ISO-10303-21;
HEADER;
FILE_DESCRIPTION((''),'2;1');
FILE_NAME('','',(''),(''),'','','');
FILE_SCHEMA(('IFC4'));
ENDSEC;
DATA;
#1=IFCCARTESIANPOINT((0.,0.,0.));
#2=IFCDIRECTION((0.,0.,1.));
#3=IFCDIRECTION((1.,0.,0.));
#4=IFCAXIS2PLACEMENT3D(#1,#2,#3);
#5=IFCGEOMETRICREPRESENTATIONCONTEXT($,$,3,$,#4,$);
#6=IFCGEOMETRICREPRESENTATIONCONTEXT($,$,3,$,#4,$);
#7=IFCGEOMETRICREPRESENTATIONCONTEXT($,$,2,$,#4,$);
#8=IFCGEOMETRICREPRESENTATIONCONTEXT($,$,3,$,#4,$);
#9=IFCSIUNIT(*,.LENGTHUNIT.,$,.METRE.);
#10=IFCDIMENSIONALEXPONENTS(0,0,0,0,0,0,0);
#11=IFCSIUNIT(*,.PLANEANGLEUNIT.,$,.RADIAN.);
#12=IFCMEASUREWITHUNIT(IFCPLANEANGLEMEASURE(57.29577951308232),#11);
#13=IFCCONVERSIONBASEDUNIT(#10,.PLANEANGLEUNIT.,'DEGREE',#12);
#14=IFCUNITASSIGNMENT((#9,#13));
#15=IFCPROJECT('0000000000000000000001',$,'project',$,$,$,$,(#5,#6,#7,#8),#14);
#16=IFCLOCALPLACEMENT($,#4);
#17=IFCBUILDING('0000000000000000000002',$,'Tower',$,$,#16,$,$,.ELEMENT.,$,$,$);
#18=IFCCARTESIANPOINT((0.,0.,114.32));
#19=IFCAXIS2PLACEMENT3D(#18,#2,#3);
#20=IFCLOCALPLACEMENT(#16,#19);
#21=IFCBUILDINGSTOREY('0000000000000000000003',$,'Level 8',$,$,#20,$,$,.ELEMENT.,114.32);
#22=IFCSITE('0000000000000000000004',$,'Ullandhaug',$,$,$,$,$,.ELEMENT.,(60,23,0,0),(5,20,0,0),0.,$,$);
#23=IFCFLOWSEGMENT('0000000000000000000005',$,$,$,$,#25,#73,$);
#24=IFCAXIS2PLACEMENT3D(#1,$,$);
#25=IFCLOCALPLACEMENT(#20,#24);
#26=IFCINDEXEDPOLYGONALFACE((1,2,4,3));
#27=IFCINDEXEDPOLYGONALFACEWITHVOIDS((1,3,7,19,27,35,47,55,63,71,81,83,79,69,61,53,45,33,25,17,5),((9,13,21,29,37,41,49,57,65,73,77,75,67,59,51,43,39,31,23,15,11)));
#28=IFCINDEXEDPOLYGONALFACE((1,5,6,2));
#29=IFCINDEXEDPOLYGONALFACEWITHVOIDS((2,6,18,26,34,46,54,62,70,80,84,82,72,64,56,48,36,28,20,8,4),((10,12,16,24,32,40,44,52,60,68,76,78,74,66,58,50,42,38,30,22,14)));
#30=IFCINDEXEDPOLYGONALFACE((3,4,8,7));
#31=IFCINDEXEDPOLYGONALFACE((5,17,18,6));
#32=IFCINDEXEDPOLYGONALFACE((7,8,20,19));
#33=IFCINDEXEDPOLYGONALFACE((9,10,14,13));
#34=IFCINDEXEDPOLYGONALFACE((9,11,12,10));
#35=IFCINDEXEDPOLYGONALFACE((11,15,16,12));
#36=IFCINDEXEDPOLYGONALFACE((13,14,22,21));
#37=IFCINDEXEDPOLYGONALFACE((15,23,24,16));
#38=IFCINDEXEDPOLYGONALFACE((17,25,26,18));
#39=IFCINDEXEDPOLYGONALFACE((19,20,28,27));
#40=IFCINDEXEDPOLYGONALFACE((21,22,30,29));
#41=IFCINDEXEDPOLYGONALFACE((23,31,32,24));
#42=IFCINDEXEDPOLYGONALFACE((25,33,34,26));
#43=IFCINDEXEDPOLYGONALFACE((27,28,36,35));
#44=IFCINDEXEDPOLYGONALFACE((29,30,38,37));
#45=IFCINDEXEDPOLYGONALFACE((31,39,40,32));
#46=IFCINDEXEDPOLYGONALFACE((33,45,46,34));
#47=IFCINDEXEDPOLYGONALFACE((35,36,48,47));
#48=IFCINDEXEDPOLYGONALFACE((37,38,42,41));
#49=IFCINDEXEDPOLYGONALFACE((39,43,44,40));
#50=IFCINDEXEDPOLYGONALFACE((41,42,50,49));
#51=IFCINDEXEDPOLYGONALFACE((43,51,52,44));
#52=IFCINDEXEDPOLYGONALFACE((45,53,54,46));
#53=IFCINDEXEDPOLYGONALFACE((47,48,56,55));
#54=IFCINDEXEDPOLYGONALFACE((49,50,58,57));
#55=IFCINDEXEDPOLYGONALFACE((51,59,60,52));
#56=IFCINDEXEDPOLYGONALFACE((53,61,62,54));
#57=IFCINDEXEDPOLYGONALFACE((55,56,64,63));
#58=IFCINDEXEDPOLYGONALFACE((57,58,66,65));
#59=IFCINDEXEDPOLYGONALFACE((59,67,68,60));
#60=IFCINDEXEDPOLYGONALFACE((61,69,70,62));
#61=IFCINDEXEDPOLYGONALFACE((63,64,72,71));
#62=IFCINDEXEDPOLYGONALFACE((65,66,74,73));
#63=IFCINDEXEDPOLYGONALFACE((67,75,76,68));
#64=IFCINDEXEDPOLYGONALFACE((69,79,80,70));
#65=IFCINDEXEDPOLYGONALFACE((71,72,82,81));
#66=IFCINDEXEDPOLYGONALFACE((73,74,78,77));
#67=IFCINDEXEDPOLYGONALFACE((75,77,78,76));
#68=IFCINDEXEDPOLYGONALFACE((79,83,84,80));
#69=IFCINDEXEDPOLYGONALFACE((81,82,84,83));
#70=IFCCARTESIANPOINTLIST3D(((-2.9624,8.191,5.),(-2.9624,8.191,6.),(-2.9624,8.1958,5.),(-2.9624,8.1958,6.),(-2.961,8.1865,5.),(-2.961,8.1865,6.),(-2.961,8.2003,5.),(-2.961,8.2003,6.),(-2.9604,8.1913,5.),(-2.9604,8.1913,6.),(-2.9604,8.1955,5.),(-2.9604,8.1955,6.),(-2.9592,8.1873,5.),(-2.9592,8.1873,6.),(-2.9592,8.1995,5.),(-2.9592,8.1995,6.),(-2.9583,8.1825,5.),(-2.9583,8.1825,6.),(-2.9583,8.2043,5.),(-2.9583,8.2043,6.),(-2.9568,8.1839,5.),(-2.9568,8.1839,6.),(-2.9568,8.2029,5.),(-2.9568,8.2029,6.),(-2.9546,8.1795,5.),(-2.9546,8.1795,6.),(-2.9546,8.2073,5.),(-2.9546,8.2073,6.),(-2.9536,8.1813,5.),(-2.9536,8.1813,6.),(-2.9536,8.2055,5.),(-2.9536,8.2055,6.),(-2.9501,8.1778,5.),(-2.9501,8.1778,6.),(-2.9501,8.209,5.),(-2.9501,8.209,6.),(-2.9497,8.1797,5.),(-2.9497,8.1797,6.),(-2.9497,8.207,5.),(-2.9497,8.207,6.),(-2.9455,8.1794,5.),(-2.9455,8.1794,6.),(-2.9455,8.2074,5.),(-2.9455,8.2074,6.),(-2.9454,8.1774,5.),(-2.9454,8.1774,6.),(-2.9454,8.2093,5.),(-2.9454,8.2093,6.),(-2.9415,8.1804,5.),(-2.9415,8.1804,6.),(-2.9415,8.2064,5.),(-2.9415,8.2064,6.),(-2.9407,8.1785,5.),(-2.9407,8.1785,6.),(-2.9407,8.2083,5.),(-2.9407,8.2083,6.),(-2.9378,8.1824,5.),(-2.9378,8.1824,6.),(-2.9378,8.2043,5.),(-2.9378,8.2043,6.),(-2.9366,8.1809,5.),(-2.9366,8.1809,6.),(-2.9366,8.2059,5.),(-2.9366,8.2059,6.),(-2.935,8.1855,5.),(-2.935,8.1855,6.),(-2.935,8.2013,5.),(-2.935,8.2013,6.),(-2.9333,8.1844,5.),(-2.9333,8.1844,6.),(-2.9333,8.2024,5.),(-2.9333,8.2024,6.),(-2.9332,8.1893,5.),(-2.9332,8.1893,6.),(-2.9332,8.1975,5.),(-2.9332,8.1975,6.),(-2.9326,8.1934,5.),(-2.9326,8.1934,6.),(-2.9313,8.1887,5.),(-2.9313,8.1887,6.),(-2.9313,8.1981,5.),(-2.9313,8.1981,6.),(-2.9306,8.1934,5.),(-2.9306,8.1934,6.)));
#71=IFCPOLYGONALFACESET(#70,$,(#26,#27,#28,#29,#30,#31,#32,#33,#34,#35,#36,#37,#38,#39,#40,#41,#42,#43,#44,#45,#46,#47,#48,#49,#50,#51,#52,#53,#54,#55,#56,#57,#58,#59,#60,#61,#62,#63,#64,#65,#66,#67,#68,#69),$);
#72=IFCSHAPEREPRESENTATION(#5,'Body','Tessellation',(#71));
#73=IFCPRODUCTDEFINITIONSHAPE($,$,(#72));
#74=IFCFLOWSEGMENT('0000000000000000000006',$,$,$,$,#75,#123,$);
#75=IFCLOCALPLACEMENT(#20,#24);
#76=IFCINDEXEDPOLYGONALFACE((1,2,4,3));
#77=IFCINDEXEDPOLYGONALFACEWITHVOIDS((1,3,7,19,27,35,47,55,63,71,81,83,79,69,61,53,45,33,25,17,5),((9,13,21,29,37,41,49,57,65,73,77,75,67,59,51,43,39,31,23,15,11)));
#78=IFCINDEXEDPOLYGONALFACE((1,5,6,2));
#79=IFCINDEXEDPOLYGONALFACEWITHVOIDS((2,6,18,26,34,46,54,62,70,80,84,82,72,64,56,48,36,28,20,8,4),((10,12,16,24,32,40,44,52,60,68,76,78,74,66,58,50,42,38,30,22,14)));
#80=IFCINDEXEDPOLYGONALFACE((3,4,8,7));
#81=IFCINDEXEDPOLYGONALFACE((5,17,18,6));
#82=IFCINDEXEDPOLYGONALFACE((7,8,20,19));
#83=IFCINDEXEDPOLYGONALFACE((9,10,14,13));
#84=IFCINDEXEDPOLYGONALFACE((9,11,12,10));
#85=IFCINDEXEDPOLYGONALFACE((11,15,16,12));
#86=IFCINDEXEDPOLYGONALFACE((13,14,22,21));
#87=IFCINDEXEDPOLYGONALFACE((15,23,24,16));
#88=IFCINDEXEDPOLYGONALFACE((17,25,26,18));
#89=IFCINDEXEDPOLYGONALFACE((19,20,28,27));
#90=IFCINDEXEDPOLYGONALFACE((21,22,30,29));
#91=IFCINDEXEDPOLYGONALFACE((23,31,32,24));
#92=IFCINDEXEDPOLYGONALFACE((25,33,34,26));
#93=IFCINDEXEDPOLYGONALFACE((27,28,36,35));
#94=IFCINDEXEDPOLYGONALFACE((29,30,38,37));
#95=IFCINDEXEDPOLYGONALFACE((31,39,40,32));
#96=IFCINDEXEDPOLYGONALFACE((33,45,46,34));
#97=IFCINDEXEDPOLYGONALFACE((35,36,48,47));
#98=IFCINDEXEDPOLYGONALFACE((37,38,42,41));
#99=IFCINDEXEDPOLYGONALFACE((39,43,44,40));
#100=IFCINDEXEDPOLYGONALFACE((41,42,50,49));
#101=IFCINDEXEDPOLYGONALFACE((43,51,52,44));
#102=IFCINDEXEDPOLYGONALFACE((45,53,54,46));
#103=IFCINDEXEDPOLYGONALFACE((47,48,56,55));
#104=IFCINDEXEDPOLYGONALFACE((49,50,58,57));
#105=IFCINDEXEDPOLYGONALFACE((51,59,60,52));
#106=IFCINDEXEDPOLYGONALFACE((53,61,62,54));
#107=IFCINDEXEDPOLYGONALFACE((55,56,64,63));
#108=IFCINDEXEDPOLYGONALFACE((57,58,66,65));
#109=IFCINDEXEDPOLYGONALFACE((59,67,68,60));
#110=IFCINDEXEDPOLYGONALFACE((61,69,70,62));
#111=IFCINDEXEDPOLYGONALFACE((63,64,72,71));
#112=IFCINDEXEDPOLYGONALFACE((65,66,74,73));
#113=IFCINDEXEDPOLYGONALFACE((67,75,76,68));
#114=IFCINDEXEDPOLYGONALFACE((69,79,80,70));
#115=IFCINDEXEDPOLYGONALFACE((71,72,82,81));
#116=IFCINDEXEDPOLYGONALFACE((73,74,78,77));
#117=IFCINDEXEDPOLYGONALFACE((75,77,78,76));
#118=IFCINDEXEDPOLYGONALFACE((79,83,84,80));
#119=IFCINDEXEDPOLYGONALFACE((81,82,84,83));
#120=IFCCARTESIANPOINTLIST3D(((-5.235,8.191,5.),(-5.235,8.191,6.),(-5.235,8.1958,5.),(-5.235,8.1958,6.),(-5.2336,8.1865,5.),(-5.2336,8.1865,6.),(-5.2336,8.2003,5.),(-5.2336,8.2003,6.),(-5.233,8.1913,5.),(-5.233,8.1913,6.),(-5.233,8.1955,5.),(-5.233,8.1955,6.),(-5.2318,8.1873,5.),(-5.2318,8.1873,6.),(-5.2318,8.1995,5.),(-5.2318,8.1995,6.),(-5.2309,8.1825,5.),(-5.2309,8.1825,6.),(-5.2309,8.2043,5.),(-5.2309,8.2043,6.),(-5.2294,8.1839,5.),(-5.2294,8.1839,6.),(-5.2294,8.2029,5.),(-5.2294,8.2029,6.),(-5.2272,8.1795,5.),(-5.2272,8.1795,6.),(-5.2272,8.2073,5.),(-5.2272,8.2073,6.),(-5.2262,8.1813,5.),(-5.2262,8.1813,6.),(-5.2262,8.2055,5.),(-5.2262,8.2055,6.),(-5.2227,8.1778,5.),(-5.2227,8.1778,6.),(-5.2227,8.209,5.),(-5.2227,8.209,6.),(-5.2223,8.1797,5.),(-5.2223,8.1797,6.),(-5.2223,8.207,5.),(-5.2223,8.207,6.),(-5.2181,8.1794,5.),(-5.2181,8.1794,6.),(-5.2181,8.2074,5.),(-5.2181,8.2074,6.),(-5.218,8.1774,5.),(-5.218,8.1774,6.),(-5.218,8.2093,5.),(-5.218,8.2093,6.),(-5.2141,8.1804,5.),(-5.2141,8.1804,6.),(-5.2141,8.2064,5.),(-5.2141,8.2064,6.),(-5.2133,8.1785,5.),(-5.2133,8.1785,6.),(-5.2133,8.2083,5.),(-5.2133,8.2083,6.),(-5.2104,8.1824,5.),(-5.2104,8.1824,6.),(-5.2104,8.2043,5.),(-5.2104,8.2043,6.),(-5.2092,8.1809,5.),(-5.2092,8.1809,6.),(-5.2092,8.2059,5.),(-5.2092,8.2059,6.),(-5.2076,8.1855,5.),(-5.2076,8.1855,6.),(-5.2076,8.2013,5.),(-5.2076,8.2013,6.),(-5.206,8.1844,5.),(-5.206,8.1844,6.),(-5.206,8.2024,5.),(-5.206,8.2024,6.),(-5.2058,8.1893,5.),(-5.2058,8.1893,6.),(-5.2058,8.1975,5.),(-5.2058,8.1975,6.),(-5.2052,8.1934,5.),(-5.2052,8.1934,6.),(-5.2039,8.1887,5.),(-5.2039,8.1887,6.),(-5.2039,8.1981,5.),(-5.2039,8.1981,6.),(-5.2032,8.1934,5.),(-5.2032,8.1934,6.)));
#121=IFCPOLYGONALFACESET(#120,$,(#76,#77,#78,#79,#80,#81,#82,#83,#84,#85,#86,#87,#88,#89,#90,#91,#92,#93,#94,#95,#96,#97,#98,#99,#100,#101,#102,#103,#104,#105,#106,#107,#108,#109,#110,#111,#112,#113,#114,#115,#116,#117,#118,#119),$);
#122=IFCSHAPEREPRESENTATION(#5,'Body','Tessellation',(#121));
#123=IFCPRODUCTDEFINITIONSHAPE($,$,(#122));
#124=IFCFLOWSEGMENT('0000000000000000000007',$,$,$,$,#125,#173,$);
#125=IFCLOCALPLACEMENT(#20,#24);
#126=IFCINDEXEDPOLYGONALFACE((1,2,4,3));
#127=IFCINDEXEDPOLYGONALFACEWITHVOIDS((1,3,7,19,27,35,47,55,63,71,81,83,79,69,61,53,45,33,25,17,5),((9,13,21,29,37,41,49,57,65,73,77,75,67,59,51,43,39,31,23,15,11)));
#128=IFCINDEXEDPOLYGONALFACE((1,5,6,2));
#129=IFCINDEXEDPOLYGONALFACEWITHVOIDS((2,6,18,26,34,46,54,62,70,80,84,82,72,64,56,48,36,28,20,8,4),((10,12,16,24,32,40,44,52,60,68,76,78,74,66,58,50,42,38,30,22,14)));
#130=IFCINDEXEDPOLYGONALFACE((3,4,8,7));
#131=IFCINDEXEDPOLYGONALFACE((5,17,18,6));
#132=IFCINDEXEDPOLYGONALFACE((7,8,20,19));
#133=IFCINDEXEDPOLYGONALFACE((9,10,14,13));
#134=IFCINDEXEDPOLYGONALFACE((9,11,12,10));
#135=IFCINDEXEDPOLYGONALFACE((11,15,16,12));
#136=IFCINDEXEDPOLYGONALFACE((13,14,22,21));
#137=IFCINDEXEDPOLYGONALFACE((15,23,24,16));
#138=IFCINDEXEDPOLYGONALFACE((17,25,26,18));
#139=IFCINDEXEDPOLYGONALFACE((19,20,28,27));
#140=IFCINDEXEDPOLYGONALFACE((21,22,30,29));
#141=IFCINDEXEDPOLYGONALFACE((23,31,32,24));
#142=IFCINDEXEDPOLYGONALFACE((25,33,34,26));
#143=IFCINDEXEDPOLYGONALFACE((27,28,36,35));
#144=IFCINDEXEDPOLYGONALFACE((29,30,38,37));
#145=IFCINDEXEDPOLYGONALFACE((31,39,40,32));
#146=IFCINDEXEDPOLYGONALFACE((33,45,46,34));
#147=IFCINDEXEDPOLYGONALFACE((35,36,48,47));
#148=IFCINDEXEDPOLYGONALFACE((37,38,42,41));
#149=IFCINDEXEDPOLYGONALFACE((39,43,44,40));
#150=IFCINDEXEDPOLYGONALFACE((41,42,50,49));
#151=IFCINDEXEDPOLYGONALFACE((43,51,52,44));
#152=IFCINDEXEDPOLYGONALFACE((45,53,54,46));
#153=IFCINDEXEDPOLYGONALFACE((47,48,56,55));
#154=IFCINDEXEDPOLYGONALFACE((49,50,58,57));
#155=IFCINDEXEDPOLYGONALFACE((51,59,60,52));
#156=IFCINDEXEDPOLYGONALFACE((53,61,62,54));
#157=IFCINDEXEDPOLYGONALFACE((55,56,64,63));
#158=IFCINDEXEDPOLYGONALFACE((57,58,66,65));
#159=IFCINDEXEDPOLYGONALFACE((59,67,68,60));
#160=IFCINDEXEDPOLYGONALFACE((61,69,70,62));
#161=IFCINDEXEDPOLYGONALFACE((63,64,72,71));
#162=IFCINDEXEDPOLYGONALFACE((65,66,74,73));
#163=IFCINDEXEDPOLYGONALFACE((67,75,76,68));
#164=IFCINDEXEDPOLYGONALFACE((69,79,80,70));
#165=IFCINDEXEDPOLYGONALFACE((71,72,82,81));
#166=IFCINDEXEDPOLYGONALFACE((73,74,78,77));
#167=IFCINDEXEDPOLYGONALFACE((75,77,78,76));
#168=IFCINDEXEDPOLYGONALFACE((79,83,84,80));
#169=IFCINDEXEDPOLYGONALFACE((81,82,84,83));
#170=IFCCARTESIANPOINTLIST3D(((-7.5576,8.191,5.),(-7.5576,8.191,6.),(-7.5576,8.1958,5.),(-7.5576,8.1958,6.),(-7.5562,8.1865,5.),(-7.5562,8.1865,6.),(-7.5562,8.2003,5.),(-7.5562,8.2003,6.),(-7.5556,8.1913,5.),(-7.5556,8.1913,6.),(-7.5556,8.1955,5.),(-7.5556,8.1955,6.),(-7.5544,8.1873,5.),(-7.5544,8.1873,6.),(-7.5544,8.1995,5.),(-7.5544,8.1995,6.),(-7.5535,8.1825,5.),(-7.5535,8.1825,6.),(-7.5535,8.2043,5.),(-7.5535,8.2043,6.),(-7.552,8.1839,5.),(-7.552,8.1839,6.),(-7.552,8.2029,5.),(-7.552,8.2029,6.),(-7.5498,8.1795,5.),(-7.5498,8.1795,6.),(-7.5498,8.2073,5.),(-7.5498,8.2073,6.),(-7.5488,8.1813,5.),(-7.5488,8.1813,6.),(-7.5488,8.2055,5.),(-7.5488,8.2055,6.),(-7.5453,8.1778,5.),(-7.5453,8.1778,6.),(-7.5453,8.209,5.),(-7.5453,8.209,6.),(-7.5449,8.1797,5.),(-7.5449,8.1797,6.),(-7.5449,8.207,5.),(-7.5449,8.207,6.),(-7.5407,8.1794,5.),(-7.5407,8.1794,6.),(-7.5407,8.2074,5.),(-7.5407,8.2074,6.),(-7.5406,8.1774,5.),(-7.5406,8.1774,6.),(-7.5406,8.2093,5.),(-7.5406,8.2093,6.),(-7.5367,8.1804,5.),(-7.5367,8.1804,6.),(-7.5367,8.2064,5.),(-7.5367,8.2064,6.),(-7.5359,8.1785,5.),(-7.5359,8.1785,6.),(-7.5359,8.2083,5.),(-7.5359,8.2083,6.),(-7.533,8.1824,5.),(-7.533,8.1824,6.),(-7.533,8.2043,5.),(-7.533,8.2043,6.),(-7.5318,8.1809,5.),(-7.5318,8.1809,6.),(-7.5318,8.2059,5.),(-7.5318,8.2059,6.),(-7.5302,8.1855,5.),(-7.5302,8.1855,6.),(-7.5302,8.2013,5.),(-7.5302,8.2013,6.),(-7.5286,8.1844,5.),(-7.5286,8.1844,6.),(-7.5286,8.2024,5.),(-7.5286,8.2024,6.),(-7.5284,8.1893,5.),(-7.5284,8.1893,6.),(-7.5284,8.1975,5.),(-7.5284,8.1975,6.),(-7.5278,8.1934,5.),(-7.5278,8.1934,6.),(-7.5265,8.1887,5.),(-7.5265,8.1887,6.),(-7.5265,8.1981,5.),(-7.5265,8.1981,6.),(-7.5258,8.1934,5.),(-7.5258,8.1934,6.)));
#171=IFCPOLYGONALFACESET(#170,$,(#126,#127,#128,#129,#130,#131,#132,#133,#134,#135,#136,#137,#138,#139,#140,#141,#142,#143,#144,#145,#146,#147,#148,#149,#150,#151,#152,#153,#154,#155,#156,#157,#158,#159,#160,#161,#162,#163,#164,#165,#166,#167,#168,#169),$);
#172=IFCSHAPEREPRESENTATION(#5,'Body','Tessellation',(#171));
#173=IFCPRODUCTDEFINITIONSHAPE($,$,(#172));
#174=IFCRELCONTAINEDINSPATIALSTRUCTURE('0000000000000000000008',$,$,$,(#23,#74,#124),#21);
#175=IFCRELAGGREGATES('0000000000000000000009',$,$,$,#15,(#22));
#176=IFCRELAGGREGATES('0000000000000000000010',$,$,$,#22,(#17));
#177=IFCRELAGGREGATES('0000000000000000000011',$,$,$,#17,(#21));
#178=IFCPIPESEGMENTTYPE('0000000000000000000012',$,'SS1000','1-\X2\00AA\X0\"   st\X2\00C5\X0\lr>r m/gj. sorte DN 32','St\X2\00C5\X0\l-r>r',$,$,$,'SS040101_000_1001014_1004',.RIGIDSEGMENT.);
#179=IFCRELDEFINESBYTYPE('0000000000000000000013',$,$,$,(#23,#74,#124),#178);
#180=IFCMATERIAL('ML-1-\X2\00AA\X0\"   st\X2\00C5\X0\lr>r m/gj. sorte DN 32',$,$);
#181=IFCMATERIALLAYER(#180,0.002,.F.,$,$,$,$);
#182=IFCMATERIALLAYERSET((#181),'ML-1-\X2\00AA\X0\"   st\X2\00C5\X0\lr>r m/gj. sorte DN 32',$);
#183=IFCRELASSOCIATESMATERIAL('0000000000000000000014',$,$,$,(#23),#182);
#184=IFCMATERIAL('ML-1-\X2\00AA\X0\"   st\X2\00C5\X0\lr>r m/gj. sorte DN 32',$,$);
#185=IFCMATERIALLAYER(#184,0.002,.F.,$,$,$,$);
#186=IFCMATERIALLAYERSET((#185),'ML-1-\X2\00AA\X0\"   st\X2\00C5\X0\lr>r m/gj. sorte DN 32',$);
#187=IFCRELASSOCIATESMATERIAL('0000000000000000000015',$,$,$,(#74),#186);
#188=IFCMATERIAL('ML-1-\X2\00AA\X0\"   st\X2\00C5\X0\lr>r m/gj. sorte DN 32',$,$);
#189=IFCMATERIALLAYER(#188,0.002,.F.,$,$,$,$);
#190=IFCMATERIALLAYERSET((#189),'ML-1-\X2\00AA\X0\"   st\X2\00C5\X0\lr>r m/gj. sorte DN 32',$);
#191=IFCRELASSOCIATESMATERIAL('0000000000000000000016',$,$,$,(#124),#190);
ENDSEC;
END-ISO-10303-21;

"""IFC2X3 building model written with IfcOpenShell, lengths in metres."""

from ifc_helpers import new_model, entity, si_unit, converted_unit, frame, origin_with_axes, origin_2d_with_axis, place, context, project, spatial, hollow_circle, extrude, material, layer, layer_set, layer_usage, type_object, element, save


model = new_model("IFC2X3")

# Units and contexts
context_of_model_1 = context(None, 3, world=origin_with_axes())
context_of_model_2 = context(None, 3, world=origin_with_axes())
context_of_model_3 = context(None, 2, world=origin_with_axes())
context_of_model_4 = context(None, 3, world=origin_with_axes())
ifc_project = project(units=[si_unit("LENGTHUNIT", "METRE"), converted_unit("PLANEANGLEUNIT", "DEGREE", entity("IfcPlaneAngleMeasure", 57.29577951308232), si_unit("PLANEANGLEUNIT", "RADIAN"), dimensions=[0, 0, 0, 0, 0, 0, 0])], contexts=[context_of_model_1, context_of_model_2, context_of_model_3, context_of_model_4])

# Site, building, storey
site = spatial("IfcSite", under=ifc_project, Name="Ullandhaug", CompositionType="ELEMENT", RefLatitude=(60, 23, 0, 0), RefLongitude=(5, 20, 0, 0), RefElevation=0.0)
building_placement = place(None, origin_with_axes())
building = spatial("IfcBuilding", under=site, at=building_placement, Name="Tower", CompositionType="ELEMENT")
storey_placement = place(building_placement, frame((0.0, 0.0, 114.32), z_axis=(0.0, 0.0, 1.0), x_axis=(1.0, 0.0, 0.0)))
storey = spatial("IfcBuildingStorey", under=building, at=storey_placement, Name="Level 8", CompositionType="ELEMENT", Elevation=114.32)

# Flow segments
ifc_material_1 = material(Name="ML-1-ª\"   stÅlr>r m/gj. sorte DN 32")
ifc_layer_1 = layer(ifc_material_1, 0.002, ventilated=False)
ifc_layer_set_1 = layer_set([ifc_layer_1], Name="ML-1-ª\"   stÅlr>r m/gj. sorte DN 32")
ifc_layer_usage_1 = layer_usage(ifc_layer_set_1, "AXIS2", "POSITIVE", 0.0)
pipe_segment_type_1 = type_object("IfcPipeSegmentType", Name="SS1000", Description="1-ª\"   stÅlr>r m/gj. sorte DN 32", ApplicableOccurrence="StÅl-r>r", ElementType="SS040101_000_1001014_1004", PredefinedType="RIGIDSEGMENT")
flow_segment_1_placement = place(storey_placement, frame((-2.9466, 8.1934, 5.0), z_axis=(0.0, 0.0, 1.0), x_axis=(1.0, 0.0, 0.0)))
element("IfcFlowSegment", 1, at=flow_segment_1_placement, inside=storey, type_object=pipe_segment_type_1, material=ifc_layer_usage_1, context=context_of_model_1, shape_type="SweptSolid", body=[
    extrude(hollow_circle(Radius=0.016, WallThickness=0.002, at=origin_2d_with_axis()), origin_with_axes(), (0.0, 0.0, 1.0), 1.0),
])
ifc_material_2 = material(Name="ML-1-ª\"   stÅlr>r m/gj. sorte DN 32")
ifc_layer_2 = layer(ifc_material_2, 0.002, ventilated=False)
ifc_layer_set_2 = layer_set([ifc_layer_2], Name="ML-1-ª\"   stÅlr>r m/gj. sorte DN 32")
ifc_layer_usage_2 = layer_usage(ifc_layer_set_2, "AXIS2", "POSITIVE", 0.0)
flow_segment_2_placement = place(storey_placement, frame((-5.2192, 8.1934, 5.0), z_axis=(0.0, 0.0, 1.0), x_axis=(1.0, 0.0, 0.0)))
element("IfcFlowSegment", 2, at=flow_segment_2_placement, inside=storey, type_object=pipe_segment_type_1, material=ifc_layer_usage_2, context=context_of_model_1, shape_type="SweptSolid", body=[
    extrude(hollow_circle(Radius=0.016, WallThickness=0.002, at=origin_2d_with_axis()), origin_with_axes(), (0.0, 0.0, 1.0), 1.0),
])
ifc_material_3 = material(Name="ML-1-ª\"   stÅlr>r m/gj. sorte DN 32")
ifc_layer_3 = layer(ifc_material_3, 0.002, ventilated=False)
ifc_layer_set_3 = layer_set([ifc_layer_3], Name="ML-1-ª\"   stÅlr>r m/gj. sorte DN 32")
ifc_layer_usage_3 = layer_usage(ifc_layer_set_3, "AXIS2", "POSITIVE", 0.0)
flow_segment_3_placement = place(storey_placement, frame((-7.5418, 8.1934, 5.0), z_axis=(0.0, 0.0, 1.0), x_axis=(1.0, 0.0, 0.0)))
element("IfcFlowSegment", 3, at=flow_segment_3_placement, inside=storey, type_object=pipe_segment_type_1, material=ifc_layer_usage_3, context=context_of_model_1, shape_type="SweptSolid", body=[
    extrude(hollow_circle(Radius=0.016, WallThickness=0.002, at=origin_2d_with_axis()), origin_with_axes(), (0.0, 0.0, 1.0), 1.0),
])

save(model, "model.ifc")
